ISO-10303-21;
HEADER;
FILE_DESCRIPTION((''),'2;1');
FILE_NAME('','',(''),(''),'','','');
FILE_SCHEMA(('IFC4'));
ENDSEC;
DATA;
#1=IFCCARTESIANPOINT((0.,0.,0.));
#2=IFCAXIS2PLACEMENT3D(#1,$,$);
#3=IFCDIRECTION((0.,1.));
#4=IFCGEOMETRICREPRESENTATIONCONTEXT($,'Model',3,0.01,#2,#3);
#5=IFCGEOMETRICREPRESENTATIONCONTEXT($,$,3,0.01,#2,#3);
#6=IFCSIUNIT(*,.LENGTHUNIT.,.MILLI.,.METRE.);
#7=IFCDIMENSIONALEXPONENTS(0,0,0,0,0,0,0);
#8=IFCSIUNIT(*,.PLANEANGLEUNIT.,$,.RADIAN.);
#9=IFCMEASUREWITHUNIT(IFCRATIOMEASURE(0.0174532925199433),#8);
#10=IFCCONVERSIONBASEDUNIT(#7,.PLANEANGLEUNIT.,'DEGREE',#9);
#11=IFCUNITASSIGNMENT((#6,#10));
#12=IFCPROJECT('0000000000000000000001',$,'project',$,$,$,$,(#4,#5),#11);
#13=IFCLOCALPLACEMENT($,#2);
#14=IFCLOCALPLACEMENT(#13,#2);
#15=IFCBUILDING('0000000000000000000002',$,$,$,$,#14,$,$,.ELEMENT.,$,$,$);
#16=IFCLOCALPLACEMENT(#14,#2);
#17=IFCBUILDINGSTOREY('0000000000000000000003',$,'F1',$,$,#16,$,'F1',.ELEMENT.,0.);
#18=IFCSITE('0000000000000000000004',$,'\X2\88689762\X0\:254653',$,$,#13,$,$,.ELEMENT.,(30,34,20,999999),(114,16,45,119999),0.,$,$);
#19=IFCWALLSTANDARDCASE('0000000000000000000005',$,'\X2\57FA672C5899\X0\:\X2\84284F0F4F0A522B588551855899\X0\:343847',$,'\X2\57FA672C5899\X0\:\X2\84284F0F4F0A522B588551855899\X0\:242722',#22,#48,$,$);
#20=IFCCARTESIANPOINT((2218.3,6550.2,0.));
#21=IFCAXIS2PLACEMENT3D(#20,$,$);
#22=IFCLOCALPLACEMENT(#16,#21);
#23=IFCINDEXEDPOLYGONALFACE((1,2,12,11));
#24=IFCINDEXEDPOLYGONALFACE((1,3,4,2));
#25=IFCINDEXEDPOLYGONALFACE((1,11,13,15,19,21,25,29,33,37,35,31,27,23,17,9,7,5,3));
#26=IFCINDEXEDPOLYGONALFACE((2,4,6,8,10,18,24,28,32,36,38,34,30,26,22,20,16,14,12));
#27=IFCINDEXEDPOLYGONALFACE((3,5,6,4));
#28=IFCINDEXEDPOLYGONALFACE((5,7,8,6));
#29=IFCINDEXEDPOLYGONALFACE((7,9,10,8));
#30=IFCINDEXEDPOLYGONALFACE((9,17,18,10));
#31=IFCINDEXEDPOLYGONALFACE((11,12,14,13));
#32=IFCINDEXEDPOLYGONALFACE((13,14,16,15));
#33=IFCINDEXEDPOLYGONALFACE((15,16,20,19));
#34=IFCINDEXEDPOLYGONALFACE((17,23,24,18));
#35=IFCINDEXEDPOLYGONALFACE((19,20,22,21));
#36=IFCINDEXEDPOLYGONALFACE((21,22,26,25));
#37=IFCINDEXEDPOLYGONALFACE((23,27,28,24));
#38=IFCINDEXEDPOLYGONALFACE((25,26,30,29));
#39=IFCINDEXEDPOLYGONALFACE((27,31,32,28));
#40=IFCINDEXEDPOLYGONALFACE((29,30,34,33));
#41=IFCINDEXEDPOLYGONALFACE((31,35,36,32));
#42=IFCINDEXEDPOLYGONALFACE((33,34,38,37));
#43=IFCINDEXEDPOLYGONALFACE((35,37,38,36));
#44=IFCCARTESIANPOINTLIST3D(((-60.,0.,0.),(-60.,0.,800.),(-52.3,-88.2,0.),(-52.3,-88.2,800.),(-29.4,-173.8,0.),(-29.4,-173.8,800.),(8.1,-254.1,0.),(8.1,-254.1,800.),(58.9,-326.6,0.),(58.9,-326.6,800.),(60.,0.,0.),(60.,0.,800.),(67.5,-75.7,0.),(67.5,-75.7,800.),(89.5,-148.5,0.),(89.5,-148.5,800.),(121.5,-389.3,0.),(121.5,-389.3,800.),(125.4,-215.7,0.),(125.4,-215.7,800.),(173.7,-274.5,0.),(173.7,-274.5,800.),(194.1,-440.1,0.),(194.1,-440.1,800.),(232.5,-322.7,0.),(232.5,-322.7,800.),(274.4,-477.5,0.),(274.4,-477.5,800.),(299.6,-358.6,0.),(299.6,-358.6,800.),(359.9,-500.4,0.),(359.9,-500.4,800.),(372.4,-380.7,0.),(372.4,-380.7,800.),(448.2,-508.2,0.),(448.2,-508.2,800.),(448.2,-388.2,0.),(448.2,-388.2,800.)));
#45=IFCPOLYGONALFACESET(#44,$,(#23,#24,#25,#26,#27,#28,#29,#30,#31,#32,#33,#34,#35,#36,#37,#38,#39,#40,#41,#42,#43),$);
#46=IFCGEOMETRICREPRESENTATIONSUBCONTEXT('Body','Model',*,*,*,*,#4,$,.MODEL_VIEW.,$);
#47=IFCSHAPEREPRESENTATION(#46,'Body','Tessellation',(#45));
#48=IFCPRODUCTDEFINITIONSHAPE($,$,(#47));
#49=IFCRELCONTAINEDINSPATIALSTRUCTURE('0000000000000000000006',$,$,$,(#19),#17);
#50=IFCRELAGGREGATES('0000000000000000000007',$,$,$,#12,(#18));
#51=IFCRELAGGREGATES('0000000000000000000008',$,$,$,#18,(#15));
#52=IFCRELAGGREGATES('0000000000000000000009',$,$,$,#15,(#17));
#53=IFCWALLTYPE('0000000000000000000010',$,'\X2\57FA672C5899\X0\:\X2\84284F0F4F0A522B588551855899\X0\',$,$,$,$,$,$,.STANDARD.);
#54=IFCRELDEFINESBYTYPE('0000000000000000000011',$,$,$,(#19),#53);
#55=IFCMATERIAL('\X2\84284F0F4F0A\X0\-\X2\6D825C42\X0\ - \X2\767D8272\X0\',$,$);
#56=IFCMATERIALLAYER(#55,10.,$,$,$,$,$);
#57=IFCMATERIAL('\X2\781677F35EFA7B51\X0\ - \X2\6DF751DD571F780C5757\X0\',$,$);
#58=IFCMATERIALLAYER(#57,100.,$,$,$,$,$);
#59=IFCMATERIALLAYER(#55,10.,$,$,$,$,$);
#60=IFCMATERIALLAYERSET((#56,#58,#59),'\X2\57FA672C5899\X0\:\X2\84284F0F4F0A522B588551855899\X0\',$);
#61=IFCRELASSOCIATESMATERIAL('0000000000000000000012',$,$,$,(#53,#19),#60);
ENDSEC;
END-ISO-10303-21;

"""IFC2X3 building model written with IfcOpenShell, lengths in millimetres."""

from ifc_helpers import new_model, entity, si_unit, converted_unit, direction, frame, frame_2d, origin, place, context, subcontext, project, spatial, polyline, circle_curve, parameter, trimmed, segment, composite_curve, outline, extrude, material, layer, layer_set, layer_usage, type_object, element, save


model = new_model("IFC2X3")

# Units and contexts
model_context = context("Model", 3, precision=0.01, world=origin(), true_north=direction((0.0, 1.0)))
context_of_model = context(None, 3, precision=0.01, world=origin(), true_north=direction((0.0, 1.0)))
body_context = subcontext(model_context, "Body", "Model", "MODEL_VIEW")
ifc_project = project(units=[si_unit("LENGTHUNIT", "METRE", prefix="MILLI"), converted_unit("PLANEANGLEUNIT", "DEGREE", entity("IfcRatioMeasure", 0.0174532925199433), si_unit("PLANEANGLEUNIT", "RADIAN"), dimensions=[0, 0, 0, 0, 0, 0, 0])], contexts=[model_context, context_of_model])

# Site, building, storey
site_placement = place(None, origin())
site = spatial("IfcSite", under=ifc_project, at=site_placement, Name="表面:254653", CompositionType="ELEMENT", RefLatitude=(30, 34, 20, 999999), RefLongitude=(114, 16, 45, 119999), RefElevation=0.0)
building_placement = place(site_placement, origin())
building = spatial("IfcBuilding", under=site, at=building_placement, CompositionType="ELEMENT")
storey_placement = place(building_placement, origin())
storey = spatial("IfcBuildingStorey", under=building, at=storey_placement, Name="F1", LongName="F1", CompositionType="ELEMENT", Elevation=0.0)

# Shared definitions
ifc_material_1 = material(Name="萨伏伊-涂层 - 白色")

# Wall
ifc_layer_1 = layer(ifc_material_1, 10.0)
ifc_material_2 = material(Name="砖石建筑 - 混凝土砌块")
ifc_layer_2 = layer(ifc_material_2, 100.0)
ifc_layer_3 = layer(ifc_material_1, 10.0)
ifc_layer_set_1 = layer_set([ifc_layer_1, ifc_layer_2, ifc_layer_3], Name="基本墙:萨伏伊别墅内墙")
wall_type = type_object("IfcWallType", Name="基本墙:萨伏伊别墅内墙", PredefinedType="STANDARD", material=ifc_layer_set_1)
ifc_layer_usage_1 = layer_usage(ifc_layer_set_1, "AXIS2", "NEGATIVE", 60.0)
wall_1_placement = place(storey_placement, frame((2218.3, 6550.2, 0.0)))
element("IfcWallStandardCase", 1, at=wall_1_placement, inside=storey, type_object=wall_type, material=ifc_layer_usage_1, Name="基本墙:萨伏伊别墅内墙:343847", ObjectType="基本墙:萨伏伊别墅内墙:242722", context=body_context, shape_type="SweptSolid", body=[
    extrude(outline(composite_curve([segment(trimmed(circle_curve(frame_2d((448.2, 0.0), x_axis=(1.0, 0.0)), 388.2), [parameter(180.0)], [parameter(270.0)], True, "PARAMETER"), False, "CONTINUOUS"), segment(polyline([(60.0, 0.0), (-60.0, 0.0)]), True, "CONTINUOUS"), segment(trimmed(circle_curve(frame_2d((448.2, 0.0), x_axis=(1.0, 0.0)), 508.2), [parameter(180.0)], [parameter(270.0)], True, "PARAMETER"), True, "CONTINUOUS"), segment(polyline([(448.2, -508.2), (448.2, -388.2)]), True, "CONTINUOUS")], self_intersect=False)), origin(), (0.0, 0.0, 1.0), 800.0),
])

save(model, "model.ifc")
